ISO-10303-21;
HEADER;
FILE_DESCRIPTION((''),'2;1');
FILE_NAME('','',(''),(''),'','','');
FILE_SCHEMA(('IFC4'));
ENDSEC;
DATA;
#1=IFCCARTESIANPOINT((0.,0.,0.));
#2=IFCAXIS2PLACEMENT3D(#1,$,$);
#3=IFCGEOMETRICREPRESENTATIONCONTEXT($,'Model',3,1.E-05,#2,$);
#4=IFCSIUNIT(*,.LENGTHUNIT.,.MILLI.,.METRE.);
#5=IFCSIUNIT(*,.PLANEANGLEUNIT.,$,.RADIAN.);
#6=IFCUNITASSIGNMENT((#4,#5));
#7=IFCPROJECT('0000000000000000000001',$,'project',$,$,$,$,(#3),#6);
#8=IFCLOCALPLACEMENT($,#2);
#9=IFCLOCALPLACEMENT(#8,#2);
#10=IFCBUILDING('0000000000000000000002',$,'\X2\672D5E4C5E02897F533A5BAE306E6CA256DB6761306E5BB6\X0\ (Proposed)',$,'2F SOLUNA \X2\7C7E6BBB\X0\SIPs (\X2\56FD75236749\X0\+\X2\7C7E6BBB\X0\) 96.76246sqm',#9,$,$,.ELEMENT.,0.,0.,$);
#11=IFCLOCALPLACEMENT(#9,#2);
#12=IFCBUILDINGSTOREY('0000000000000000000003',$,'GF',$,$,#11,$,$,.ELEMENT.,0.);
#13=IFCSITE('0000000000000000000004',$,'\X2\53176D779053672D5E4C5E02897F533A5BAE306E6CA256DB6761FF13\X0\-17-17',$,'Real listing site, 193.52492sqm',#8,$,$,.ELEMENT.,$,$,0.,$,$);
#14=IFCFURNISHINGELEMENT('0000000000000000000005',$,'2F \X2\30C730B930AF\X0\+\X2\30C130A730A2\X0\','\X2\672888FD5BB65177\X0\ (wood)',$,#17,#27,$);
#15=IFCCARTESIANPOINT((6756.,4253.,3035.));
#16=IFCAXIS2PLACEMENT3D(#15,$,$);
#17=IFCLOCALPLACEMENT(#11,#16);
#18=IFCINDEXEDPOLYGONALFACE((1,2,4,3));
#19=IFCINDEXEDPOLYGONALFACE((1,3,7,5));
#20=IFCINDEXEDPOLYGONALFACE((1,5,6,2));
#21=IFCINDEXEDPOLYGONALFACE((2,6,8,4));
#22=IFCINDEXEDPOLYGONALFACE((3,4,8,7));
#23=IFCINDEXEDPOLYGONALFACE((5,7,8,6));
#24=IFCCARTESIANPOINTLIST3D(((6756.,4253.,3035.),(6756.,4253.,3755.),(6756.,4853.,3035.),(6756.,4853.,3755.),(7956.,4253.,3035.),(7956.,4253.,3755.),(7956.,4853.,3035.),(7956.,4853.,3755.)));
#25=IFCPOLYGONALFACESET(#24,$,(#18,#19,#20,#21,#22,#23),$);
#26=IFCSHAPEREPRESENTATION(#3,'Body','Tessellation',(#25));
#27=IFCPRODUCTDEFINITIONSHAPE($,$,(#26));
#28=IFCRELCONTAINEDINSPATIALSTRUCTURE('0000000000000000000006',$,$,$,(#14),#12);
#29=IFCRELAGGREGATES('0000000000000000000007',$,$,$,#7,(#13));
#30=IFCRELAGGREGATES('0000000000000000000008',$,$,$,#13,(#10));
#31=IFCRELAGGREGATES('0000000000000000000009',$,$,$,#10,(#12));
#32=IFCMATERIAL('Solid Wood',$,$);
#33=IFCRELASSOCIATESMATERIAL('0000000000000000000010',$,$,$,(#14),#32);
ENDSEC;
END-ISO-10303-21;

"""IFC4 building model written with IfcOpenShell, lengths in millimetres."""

from ifc_helpers import new_model, si_unit, frame, frame_2d, origin, place, context, project, spatial, rectangle, extrude, material, element, save


model = new_model("IFC4")

# Units and contexts
model_context = context("Model", 3, precision=1e-05, world=origin())
ifc_project = project(units=[si_unit("LENGTHUNIT", "METRE", prefix="MILLI"), si_unit("PLANEANGLEUNIT", "RADIAN")], contexts=[model_context])

# Site, building, storey
site_placement = place(None, origin())
site = spatial("IfcSite", under=ifc_project, at=site_placement, Name="北海道札幌市西区宮の沢四条３-17-17", ObjectType="Real listing site, 193.52492sqm", CompositionType="ELEMENT", RefElevation=0.0)
building_placement = place(site_placement, origin())
building = spatial("IfcBuilding", under=site, at=building_placement, Name="札幌市西区宮の沢四条の家 (Proposed)", ObjectType="2F SOLUNA 籾殻SIPs (国産杉+籾殻) 96.76246sqm", CompositionType="ELEMENT", ElevationOfRefHeight=0.0, ElevationOfTerrain=0.0)
storey_placement = place(building_placement, origin())
storey = spatial("IfcBuildingStorey", under=building, at=storey_placement, Name="GF", CompositionType="ELEMENT", Elevation=0.0)

# Shared definitions
ifc_material_1 = material(Name="Solid Wood")

# Furnishing element
furnishing_1_placement = place(storey_placement, frame((6756.0, 4253.0, 3035.0)))
element("IfcFurnishingElement", 1, at=furnishing_1_placement, inside=storey, material=ifc_material_1, Name="2F デスク+チェア", Description="木製家具 (wood)", context=model_context, shape_type="SweptSolid", body=[
    extrude(rectangle(XDim=1200.0, YDim=600.0, at=frame_2d((600.0, 300.0))), frame((6756.0, 4253.0, 3035.0)), (0.0, 0.0, 1.0), 720.0),
])

save(model, "model.ifc")
